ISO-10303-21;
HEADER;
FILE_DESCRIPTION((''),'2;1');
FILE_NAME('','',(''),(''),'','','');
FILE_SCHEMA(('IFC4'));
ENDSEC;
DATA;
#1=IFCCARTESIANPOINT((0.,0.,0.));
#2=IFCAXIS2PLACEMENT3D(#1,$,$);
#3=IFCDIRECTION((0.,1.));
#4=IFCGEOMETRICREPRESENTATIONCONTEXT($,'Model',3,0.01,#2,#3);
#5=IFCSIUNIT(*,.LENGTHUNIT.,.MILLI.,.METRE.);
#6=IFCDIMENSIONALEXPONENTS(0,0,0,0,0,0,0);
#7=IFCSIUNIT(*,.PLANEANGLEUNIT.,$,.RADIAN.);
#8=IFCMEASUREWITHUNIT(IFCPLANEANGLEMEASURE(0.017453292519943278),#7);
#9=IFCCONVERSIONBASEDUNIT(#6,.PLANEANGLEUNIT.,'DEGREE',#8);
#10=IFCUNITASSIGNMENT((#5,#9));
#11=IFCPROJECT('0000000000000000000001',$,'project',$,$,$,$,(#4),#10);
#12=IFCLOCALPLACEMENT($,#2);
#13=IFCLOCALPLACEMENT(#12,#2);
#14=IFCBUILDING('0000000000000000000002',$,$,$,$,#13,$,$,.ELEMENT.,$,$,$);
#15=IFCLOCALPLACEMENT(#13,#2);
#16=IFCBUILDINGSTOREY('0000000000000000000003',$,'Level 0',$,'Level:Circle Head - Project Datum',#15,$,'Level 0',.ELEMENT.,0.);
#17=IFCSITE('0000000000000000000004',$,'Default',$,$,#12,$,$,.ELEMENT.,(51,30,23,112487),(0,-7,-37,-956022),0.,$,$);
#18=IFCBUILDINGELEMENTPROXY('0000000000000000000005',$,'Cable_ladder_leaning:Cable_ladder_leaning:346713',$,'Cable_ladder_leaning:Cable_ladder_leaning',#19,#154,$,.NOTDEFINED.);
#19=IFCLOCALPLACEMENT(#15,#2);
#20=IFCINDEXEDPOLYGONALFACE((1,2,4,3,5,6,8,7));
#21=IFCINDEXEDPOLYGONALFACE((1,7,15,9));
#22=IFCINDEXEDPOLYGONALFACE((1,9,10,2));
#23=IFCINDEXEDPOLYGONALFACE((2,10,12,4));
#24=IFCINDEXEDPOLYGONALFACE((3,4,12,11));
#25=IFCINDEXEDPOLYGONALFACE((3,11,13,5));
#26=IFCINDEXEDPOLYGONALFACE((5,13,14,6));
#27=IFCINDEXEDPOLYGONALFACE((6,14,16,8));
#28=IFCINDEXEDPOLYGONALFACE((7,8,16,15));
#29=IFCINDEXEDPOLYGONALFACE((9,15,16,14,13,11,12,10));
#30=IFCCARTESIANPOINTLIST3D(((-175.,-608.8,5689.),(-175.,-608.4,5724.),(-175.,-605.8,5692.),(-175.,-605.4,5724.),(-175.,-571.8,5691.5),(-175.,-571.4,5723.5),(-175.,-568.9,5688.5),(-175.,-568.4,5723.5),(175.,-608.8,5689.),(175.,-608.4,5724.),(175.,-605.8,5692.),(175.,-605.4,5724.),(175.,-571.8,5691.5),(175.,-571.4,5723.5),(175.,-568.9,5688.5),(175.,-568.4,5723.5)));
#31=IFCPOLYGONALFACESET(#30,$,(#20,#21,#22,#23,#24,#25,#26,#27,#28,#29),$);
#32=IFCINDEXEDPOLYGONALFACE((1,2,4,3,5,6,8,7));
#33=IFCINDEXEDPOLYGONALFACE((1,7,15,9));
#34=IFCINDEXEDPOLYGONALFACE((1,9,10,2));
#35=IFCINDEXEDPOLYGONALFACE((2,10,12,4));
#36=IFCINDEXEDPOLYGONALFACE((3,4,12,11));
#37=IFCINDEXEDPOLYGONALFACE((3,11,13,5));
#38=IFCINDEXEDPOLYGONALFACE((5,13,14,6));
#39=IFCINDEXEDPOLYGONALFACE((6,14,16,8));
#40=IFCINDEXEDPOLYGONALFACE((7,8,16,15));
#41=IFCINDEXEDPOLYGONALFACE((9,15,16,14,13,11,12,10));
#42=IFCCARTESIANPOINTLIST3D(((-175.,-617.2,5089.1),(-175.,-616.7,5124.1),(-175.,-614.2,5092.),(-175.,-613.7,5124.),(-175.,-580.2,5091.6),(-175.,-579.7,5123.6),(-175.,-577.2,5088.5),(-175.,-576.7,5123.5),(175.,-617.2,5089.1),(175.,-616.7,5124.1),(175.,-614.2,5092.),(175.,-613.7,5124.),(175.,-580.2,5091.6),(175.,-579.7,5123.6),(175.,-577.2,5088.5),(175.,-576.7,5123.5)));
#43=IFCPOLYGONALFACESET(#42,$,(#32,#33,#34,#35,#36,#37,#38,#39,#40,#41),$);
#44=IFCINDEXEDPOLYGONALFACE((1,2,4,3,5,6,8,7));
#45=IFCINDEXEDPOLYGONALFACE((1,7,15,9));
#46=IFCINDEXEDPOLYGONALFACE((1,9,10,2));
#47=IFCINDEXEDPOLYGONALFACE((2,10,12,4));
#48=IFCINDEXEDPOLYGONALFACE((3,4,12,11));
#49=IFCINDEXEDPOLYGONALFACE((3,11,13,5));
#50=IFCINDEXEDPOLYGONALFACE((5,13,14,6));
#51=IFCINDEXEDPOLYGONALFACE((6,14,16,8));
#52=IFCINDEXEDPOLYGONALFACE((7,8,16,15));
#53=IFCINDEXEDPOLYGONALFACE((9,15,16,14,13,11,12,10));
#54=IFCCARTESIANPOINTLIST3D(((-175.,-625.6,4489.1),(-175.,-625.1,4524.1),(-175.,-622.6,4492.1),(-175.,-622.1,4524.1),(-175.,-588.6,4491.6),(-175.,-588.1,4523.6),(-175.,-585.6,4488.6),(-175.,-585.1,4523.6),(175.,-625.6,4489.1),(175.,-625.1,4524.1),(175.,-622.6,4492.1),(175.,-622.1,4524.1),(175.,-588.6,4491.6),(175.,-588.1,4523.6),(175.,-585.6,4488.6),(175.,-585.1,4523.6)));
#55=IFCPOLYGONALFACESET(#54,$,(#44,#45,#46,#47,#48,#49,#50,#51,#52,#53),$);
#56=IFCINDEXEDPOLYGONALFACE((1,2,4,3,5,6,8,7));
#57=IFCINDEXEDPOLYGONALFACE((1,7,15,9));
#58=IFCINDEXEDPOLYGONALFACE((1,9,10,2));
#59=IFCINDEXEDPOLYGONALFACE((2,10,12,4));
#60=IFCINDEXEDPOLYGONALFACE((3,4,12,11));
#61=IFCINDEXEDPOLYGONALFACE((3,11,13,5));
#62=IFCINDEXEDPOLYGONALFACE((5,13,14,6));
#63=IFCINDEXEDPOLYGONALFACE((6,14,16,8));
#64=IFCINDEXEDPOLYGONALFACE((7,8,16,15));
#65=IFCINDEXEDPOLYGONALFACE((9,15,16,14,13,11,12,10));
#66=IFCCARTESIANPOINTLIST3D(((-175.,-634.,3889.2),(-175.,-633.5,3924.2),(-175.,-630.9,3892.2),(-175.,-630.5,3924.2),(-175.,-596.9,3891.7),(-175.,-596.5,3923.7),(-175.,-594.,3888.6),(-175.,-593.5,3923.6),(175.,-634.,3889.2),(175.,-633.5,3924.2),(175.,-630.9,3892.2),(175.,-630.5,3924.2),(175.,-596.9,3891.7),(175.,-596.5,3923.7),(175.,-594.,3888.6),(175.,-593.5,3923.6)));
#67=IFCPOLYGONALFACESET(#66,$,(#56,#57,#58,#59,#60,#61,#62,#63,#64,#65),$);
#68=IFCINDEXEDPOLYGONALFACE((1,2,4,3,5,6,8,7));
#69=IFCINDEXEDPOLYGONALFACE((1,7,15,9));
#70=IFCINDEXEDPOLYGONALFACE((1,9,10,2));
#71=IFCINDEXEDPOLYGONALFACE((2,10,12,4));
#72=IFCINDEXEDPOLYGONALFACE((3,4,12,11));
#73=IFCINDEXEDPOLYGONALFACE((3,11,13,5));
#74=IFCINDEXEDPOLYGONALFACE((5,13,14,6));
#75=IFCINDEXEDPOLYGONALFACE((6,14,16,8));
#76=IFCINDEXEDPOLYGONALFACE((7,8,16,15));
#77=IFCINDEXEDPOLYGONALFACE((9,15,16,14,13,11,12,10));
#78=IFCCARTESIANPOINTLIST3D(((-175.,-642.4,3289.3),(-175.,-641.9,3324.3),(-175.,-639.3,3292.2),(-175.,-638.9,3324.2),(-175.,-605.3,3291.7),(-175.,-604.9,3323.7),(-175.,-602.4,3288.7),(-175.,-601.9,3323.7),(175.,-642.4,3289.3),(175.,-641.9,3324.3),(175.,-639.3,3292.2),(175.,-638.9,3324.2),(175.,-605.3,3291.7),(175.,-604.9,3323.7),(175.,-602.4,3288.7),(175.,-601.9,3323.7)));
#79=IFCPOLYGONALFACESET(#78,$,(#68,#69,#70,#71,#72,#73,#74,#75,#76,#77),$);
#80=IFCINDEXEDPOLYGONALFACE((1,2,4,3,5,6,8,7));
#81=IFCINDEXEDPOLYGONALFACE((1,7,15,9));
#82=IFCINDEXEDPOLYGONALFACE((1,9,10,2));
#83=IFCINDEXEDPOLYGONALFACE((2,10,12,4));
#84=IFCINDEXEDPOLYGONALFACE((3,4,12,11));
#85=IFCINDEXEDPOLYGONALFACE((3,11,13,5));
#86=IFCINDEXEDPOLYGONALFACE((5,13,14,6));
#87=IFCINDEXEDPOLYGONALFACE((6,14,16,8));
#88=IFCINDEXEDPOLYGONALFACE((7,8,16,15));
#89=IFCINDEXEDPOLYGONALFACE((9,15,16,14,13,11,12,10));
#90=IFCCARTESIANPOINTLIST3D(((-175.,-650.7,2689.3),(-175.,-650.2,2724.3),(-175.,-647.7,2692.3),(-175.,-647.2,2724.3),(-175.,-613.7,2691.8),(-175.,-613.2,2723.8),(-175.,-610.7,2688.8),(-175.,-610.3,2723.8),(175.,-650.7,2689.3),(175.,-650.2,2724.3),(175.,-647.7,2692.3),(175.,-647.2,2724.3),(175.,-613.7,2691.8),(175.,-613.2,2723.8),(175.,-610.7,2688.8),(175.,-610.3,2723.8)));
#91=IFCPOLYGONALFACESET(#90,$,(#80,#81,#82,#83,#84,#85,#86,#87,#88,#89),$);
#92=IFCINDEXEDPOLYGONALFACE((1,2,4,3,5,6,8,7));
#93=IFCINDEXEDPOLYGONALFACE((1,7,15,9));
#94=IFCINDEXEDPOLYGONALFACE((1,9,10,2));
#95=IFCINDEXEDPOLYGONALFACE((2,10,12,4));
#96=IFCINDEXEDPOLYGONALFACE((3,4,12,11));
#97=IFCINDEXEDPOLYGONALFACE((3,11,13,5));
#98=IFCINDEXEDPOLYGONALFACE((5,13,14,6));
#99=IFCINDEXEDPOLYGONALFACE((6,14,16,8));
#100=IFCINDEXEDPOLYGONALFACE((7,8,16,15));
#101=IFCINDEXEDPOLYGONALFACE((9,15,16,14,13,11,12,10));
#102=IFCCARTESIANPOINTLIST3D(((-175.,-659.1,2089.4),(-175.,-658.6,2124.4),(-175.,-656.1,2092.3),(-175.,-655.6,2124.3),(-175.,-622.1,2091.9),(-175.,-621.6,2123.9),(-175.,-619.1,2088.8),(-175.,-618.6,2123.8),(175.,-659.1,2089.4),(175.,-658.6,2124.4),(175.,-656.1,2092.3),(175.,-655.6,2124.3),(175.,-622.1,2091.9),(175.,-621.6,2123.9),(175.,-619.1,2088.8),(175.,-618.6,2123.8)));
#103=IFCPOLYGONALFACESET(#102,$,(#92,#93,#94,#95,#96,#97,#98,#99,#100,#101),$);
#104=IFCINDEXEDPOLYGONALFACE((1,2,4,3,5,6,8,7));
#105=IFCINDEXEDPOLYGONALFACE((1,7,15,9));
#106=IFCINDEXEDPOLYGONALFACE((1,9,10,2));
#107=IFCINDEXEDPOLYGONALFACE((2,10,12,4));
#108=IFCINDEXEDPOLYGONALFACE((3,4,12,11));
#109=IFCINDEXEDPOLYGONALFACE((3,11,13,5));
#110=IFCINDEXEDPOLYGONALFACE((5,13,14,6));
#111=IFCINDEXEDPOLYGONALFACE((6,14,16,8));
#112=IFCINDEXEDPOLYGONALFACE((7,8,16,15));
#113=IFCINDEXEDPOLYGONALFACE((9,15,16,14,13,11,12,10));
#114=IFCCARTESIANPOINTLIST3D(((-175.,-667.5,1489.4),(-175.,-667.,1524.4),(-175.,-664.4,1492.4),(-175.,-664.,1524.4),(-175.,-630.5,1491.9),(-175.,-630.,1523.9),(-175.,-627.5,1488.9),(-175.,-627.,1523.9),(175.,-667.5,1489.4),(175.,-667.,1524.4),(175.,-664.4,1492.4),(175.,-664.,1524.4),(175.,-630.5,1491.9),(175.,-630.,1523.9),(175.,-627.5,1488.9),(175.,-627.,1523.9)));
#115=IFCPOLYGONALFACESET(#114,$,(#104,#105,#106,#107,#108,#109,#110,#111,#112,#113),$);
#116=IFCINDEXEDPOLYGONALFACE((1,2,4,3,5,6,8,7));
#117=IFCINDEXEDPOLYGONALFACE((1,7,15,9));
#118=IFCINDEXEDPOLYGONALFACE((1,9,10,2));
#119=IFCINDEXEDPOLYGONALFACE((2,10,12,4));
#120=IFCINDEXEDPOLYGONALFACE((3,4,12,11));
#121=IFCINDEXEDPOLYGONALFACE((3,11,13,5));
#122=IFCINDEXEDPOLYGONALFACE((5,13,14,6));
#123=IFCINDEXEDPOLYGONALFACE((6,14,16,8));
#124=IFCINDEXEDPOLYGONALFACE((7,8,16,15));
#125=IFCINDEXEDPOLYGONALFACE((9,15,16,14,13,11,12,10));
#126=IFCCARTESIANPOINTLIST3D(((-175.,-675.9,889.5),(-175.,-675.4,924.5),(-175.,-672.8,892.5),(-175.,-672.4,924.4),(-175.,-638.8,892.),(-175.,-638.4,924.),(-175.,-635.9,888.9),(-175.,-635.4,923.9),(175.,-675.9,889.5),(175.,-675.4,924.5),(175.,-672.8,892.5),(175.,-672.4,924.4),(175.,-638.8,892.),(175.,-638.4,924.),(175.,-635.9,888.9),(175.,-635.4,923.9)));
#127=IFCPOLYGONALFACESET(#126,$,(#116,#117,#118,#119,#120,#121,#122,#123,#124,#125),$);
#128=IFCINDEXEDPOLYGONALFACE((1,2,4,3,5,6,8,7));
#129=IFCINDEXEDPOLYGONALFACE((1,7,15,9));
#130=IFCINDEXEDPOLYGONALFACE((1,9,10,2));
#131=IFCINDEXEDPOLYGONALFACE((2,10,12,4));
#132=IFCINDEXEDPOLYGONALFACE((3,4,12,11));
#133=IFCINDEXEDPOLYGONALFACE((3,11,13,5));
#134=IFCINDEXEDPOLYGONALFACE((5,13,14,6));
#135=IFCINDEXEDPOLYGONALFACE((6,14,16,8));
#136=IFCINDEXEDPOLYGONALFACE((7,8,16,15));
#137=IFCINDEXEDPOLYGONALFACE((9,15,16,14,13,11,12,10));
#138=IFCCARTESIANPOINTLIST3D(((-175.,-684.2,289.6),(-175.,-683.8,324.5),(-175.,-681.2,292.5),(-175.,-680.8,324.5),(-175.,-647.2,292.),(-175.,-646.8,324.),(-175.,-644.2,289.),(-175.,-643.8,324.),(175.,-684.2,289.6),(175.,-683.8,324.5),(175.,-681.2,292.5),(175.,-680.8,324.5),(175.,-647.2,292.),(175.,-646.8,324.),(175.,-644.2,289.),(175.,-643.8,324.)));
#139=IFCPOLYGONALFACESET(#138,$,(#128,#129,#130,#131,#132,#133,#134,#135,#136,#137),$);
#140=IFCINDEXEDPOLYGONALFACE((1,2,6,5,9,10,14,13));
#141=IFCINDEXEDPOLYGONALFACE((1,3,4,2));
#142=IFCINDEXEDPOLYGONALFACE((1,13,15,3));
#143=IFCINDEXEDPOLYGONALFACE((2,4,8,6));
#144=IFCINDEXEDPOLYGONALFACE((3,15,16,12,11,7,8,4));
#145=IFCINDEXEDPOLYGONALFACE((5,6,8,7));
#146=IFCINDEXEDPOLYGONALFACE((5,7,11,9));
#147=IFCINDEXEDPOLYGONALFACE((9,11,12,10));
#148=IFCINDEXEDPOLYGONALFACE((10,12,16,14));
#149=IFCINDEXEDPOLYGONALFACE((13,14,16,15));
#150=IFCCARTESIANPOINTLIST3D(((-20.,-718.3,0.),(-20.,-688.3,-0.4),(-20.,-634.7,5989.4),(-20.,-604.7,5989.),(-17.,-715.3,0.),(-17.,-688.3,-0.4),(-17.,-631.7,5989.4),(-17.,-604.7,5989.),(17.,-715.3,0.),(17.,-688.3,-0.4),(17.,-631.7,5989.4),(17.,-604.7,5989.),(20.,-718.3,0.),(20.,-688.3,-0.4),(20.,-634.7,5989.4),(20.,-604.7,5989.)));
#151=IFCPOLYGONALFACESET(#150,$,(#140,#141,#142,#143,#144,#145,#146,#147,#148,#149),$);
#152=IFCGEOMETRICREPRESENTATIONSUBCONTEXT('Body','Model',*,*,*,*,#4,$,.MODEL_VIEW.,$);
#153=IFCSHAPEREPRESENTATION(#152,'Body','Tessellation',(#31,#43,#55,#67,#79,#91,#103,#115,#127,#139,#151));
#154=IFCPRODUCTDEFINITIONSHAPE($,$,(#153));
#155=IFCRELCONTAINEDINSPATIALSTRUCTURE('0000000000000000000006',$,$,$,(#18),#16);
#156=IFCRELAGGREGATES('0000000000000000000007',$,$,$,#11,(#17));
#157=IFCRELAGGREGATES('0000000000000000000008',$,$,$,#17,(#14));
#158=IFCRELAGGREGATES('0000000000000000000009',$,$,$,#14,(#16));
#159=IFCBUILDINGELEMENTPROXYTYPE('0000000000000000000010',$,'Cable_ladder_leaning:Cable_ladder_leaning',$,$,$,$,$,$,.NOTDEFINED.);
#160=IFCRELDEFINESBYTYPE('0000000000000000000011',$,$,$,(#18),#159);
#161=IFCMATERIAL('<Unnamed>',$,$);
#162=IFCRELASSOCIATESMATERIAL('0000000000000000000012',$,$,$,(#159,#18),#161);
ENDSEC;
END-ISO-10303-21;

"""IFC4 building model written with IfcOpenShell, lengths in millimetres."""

from ifc_helpers import new_model, entity, si_unit, converted_unit, direction, frame, origin, place, context, subcontext, project, spatial, indexed_curve, outline, extrude, source, transform, mapped, material, type_object, type_shapes, element, save


model = new_model("IFC4")

# Units and contexts
model_context = context("Model", 3, precision=0.01, world=origin(), true_north=direction((0.0, 1.0)))
body_context = subcontext(model_context, "Body", "Model", "MODEL_VIEW")
ifc_project = project(units=[si_unit("LENGTHUNIT", "METRE", prefix="MILLI"), converted_unit("PLANEANGLEUNIT", "DEGREE", entity("IfcPlaneAngleMeasure", 0.017453292519943278), si_unit("PLANEANGLEUNIT", "RADIAN"), dimensions=[0, 0, 0, 0, 0, 0, 0])], contexts=[model_context])

# Site, building, storey
site_placement = place(None, origin())
site = spatial("IfcSite", under=ifc_project, at=site_placement, Name="Default", CompositionType="ELEMENT", RefLatitude=(51, 30, 23, 112487), RefLongitude=(0, -7, -37, -956022), RefElevation=0.0)
building_placement = place(site_placement, origin())
building = spatial("IfcBuilding", under=site, at=building_placement, CompositionType="ELEMENT")
storey_placement = place(building_placement, origin())
storey = spatial("IfcBuildingStorey", under=building, at=storey_placement, Name="Level 0", ObjectType="Level:Circle Head - Project Datum", LongName="Level 0", CompositionType="ELEMENT", Elevation=0.0)

# Shared definitions
ifc_material_1 = material(Name="<Unnamed>")

# Building element proxy
building_element_proxy_type_1 = type_object("IfcBuildingElementProxyType", Name="Cable_ladder_leaning:Cable_ladder_leaning", PredefinedType="NOTDEFINED", material=ifc_material_1)
shared_shape_1 = source(origin(), body_context, "Body", "SweptSolid", [
    extrude(outline(indexed_curve([(-20.0, -18.2), (20.0, -18.2), (20.0, 16.8), (17.0, 16.8), (17.0, -15.2), (-17.0, -15.2), (-17.0, 16.8), (-20.0, 16.8), (-20.0, -18.2)], self_intersect=False)), frame((-175.0, 129.7, 5707.0), z_axis=(1.0, 0.0, 0.0), x_axis=(0.0, 0.999903, -0.013962)), (0.0, 0.0, 1.0), 350.0),
    extrude(outline(indexed_curve([(-20.0, -18.2), (20.0, -18.2), (20.0, 16.7), (17.0, 16.8), (17.0, -15.3), (-17.0, -15.3), (-17.0, 16.7), (-20.0, 16.7), (-20.0, -18.2)], self_intersect=False)), frame((-175.0, 121.3, 5107.1), z_axis=(1.0, 0.0, 0.0), x_axis=(0.0, 0.999903, -0.013962)), (0.0, 0.0, 1.0), 350.0),
    extrude(outline(indexed_curve([(-20.0, -18.2), (20.0, -18.2), (20.0, 16.8), (17.0, 16.8), (17.0, -15.2), (-17.0, -15.2), (-17.0, 16.8), (-20.0, 16.8), (-20.0, -18.2)], self_intersect=False)), frame((-175.0, 112.9, 4507.1), z_axis=(1.0, 0.0, 0.0), x_axis=(0.0, 0.999903, -0.013962)), (0.0, 0.0, 1.0), 350.0),
    extrude(outline(indexed_curve([(-20.0, -18.2), (20.0, -18.2), (20.0, 16.8), (17.0, 16.7), (17.0, -15.3), (-17.0, -15.3), (-17.0, 16.7), (-20.0, 16.8), (-20.0, -18.2)], self_intersect=False)), frame((-175.0, 104.6, 3907.2), z_axis=(1.0, 0.0, 0.0), x_axis=(0.0, 0.999903, -0.013962)), (0.0, 0.0, 1.0), 350.0),
    extrude(outline(indexed_curve([(-20.0, -18.2), (20.0, -18.2), (20.0, 16.8), (17.0, 16.7), (17.0, -15.3), (-17.0, -15.3), (-17.0, 16.7), (-20.0, 16.8), (-20.0, -18.2)], self_intersect=False)), frame((-175.0, 96.2, 3307.2), z_axis=(1.0, 0.0, 0.0), x_axis=(0.0, 0.999903, -0.013962)), (0.0, 0.0, 1.0), 350.0),
    extrude(outline(indexed_curve([(-20.0, -18.2), (20.0, -18.2), (20.0, 16.8), (17.0, 16.7), (17.0, -15.3), (-17.0, -15.3), (-17.0, 16.7), (-20.0, 16.8), (-20.0, -18.2)], self_intersect=False)), frame((-175.0, 87.8, 2707.3), z_axis=(1.0, 0.0, 0.0), x_axis=(0.0, 0.999903, -0.013962)), (0.0, 0.0, 1.0), 350.0),
    extrude(outline(indexed_curve([(-20.0, -18.2), (20.0, -18.2), (20.0, 16.7), (17.0, 16.7), (17.0, -15.3), (-17.0, -15.2), (-17.0, 16.7), (-20.0, 16.8), (-20.0, -18.2)], self_intersect=False)), frame((-175.0, 79.4, 2107.3), z_axis=(1.0, 0.0, 0.0), x_axis=(0.0, 0.999903, -0.013962)), (0.0, 0.0, 1.0), 350.0),
    extrude(outline(indexed_curve([(-20.0, -18.2), (20.0, -18.2), (20.0, 16.7), (17.0, 16.7), (17.0, -15.3), (-17.0, -15.2), (-17.0, 16.7), (-20.0, 16.8), (-20.0, -18.2)], self_intersect=False)), frame((-175.0, 71.1, 1507.4), z_axis=(1.0, 0.0, 0.0), x_axis=(0.0, 0.999903, -0.013962)), (0.0, 0.0, 1.0), 350.0),
    extrude(outline(indexed_curve([(-20.0, -18.2), (20.0, -18.2), (20.0, 16.7), (17.0, 16.7), (17.0, -15.3), (-17.0, -15.3), (-17.0, 16.7), (-20.0, 16.7), (-20.0, -18.2)], self_intersect=False)), frame((-175.0, 62.7, 907.5), z_axis=(1.0, 0.0, 0.0), x_axis=(0.0, 0.999903, -0.013962)), (0.0, 0.0, 1.0), 350.0),
    extrude(outline(indexed_curve([(-20.0, -18.2), (20.0, -18.2), (20.0, 16.7), (17.0, 16.7), (17.0, -15.3), (-17.0, -15.3), (-17.0, 16.7), (-20.0, 16.7), (-20.0, -18.2)], self_intersect=False)), frame((-175.0, 54.3, 307.5), z_axis=(1.0, 0.0, 0.0), x_axis=(0.0, 0.999903, -0.013962)), (0.0, 0.0, 1.0), 350.0),
    extrude(outline(indexed_curve([(-14.2, -20.0), (15.8, -20.0), (15.8, 20.0), (-14.2, 20.0), (-14.2, 17.0), (12.8, 17.0), (12.7, -17.0), (-14.2, -17.0), (-14.2, -20.0)], self_intersect=False)), frame((0.0, 15.7, -0.2), z_axis=(0.0, 0.013962, 0.999903), x_axis=(0.0, -0.999903, 0.013962)), (0.0, 0.0, 1.0), 5990.0),
])
type_shapes(building_element_proxy_type_1, [shared_shape_1])
proxy_1_placement = place(storey_placement, frame((0.0, -718.3, 0.0)))
element("IfcBuildingElementProxy", 1, at=proxy_1_placement, inside=storey, type_object=building_element_proxy_type_1, material=ifc_material_1, Name="Cable_ladder_leaning:Cable_ladder_leaning:346713", ObjectType="Cable_ladder_leaning:Cable_ladder_leaning", PredefinedType="NOTDEFINED", context=body_context, shape_type="MappedRepresentation", body=[
    mapped(shared_shape_1, transform((0.0, 0.0, 0.0), scale=1.0)),
])

save(model, "model.ifc")
